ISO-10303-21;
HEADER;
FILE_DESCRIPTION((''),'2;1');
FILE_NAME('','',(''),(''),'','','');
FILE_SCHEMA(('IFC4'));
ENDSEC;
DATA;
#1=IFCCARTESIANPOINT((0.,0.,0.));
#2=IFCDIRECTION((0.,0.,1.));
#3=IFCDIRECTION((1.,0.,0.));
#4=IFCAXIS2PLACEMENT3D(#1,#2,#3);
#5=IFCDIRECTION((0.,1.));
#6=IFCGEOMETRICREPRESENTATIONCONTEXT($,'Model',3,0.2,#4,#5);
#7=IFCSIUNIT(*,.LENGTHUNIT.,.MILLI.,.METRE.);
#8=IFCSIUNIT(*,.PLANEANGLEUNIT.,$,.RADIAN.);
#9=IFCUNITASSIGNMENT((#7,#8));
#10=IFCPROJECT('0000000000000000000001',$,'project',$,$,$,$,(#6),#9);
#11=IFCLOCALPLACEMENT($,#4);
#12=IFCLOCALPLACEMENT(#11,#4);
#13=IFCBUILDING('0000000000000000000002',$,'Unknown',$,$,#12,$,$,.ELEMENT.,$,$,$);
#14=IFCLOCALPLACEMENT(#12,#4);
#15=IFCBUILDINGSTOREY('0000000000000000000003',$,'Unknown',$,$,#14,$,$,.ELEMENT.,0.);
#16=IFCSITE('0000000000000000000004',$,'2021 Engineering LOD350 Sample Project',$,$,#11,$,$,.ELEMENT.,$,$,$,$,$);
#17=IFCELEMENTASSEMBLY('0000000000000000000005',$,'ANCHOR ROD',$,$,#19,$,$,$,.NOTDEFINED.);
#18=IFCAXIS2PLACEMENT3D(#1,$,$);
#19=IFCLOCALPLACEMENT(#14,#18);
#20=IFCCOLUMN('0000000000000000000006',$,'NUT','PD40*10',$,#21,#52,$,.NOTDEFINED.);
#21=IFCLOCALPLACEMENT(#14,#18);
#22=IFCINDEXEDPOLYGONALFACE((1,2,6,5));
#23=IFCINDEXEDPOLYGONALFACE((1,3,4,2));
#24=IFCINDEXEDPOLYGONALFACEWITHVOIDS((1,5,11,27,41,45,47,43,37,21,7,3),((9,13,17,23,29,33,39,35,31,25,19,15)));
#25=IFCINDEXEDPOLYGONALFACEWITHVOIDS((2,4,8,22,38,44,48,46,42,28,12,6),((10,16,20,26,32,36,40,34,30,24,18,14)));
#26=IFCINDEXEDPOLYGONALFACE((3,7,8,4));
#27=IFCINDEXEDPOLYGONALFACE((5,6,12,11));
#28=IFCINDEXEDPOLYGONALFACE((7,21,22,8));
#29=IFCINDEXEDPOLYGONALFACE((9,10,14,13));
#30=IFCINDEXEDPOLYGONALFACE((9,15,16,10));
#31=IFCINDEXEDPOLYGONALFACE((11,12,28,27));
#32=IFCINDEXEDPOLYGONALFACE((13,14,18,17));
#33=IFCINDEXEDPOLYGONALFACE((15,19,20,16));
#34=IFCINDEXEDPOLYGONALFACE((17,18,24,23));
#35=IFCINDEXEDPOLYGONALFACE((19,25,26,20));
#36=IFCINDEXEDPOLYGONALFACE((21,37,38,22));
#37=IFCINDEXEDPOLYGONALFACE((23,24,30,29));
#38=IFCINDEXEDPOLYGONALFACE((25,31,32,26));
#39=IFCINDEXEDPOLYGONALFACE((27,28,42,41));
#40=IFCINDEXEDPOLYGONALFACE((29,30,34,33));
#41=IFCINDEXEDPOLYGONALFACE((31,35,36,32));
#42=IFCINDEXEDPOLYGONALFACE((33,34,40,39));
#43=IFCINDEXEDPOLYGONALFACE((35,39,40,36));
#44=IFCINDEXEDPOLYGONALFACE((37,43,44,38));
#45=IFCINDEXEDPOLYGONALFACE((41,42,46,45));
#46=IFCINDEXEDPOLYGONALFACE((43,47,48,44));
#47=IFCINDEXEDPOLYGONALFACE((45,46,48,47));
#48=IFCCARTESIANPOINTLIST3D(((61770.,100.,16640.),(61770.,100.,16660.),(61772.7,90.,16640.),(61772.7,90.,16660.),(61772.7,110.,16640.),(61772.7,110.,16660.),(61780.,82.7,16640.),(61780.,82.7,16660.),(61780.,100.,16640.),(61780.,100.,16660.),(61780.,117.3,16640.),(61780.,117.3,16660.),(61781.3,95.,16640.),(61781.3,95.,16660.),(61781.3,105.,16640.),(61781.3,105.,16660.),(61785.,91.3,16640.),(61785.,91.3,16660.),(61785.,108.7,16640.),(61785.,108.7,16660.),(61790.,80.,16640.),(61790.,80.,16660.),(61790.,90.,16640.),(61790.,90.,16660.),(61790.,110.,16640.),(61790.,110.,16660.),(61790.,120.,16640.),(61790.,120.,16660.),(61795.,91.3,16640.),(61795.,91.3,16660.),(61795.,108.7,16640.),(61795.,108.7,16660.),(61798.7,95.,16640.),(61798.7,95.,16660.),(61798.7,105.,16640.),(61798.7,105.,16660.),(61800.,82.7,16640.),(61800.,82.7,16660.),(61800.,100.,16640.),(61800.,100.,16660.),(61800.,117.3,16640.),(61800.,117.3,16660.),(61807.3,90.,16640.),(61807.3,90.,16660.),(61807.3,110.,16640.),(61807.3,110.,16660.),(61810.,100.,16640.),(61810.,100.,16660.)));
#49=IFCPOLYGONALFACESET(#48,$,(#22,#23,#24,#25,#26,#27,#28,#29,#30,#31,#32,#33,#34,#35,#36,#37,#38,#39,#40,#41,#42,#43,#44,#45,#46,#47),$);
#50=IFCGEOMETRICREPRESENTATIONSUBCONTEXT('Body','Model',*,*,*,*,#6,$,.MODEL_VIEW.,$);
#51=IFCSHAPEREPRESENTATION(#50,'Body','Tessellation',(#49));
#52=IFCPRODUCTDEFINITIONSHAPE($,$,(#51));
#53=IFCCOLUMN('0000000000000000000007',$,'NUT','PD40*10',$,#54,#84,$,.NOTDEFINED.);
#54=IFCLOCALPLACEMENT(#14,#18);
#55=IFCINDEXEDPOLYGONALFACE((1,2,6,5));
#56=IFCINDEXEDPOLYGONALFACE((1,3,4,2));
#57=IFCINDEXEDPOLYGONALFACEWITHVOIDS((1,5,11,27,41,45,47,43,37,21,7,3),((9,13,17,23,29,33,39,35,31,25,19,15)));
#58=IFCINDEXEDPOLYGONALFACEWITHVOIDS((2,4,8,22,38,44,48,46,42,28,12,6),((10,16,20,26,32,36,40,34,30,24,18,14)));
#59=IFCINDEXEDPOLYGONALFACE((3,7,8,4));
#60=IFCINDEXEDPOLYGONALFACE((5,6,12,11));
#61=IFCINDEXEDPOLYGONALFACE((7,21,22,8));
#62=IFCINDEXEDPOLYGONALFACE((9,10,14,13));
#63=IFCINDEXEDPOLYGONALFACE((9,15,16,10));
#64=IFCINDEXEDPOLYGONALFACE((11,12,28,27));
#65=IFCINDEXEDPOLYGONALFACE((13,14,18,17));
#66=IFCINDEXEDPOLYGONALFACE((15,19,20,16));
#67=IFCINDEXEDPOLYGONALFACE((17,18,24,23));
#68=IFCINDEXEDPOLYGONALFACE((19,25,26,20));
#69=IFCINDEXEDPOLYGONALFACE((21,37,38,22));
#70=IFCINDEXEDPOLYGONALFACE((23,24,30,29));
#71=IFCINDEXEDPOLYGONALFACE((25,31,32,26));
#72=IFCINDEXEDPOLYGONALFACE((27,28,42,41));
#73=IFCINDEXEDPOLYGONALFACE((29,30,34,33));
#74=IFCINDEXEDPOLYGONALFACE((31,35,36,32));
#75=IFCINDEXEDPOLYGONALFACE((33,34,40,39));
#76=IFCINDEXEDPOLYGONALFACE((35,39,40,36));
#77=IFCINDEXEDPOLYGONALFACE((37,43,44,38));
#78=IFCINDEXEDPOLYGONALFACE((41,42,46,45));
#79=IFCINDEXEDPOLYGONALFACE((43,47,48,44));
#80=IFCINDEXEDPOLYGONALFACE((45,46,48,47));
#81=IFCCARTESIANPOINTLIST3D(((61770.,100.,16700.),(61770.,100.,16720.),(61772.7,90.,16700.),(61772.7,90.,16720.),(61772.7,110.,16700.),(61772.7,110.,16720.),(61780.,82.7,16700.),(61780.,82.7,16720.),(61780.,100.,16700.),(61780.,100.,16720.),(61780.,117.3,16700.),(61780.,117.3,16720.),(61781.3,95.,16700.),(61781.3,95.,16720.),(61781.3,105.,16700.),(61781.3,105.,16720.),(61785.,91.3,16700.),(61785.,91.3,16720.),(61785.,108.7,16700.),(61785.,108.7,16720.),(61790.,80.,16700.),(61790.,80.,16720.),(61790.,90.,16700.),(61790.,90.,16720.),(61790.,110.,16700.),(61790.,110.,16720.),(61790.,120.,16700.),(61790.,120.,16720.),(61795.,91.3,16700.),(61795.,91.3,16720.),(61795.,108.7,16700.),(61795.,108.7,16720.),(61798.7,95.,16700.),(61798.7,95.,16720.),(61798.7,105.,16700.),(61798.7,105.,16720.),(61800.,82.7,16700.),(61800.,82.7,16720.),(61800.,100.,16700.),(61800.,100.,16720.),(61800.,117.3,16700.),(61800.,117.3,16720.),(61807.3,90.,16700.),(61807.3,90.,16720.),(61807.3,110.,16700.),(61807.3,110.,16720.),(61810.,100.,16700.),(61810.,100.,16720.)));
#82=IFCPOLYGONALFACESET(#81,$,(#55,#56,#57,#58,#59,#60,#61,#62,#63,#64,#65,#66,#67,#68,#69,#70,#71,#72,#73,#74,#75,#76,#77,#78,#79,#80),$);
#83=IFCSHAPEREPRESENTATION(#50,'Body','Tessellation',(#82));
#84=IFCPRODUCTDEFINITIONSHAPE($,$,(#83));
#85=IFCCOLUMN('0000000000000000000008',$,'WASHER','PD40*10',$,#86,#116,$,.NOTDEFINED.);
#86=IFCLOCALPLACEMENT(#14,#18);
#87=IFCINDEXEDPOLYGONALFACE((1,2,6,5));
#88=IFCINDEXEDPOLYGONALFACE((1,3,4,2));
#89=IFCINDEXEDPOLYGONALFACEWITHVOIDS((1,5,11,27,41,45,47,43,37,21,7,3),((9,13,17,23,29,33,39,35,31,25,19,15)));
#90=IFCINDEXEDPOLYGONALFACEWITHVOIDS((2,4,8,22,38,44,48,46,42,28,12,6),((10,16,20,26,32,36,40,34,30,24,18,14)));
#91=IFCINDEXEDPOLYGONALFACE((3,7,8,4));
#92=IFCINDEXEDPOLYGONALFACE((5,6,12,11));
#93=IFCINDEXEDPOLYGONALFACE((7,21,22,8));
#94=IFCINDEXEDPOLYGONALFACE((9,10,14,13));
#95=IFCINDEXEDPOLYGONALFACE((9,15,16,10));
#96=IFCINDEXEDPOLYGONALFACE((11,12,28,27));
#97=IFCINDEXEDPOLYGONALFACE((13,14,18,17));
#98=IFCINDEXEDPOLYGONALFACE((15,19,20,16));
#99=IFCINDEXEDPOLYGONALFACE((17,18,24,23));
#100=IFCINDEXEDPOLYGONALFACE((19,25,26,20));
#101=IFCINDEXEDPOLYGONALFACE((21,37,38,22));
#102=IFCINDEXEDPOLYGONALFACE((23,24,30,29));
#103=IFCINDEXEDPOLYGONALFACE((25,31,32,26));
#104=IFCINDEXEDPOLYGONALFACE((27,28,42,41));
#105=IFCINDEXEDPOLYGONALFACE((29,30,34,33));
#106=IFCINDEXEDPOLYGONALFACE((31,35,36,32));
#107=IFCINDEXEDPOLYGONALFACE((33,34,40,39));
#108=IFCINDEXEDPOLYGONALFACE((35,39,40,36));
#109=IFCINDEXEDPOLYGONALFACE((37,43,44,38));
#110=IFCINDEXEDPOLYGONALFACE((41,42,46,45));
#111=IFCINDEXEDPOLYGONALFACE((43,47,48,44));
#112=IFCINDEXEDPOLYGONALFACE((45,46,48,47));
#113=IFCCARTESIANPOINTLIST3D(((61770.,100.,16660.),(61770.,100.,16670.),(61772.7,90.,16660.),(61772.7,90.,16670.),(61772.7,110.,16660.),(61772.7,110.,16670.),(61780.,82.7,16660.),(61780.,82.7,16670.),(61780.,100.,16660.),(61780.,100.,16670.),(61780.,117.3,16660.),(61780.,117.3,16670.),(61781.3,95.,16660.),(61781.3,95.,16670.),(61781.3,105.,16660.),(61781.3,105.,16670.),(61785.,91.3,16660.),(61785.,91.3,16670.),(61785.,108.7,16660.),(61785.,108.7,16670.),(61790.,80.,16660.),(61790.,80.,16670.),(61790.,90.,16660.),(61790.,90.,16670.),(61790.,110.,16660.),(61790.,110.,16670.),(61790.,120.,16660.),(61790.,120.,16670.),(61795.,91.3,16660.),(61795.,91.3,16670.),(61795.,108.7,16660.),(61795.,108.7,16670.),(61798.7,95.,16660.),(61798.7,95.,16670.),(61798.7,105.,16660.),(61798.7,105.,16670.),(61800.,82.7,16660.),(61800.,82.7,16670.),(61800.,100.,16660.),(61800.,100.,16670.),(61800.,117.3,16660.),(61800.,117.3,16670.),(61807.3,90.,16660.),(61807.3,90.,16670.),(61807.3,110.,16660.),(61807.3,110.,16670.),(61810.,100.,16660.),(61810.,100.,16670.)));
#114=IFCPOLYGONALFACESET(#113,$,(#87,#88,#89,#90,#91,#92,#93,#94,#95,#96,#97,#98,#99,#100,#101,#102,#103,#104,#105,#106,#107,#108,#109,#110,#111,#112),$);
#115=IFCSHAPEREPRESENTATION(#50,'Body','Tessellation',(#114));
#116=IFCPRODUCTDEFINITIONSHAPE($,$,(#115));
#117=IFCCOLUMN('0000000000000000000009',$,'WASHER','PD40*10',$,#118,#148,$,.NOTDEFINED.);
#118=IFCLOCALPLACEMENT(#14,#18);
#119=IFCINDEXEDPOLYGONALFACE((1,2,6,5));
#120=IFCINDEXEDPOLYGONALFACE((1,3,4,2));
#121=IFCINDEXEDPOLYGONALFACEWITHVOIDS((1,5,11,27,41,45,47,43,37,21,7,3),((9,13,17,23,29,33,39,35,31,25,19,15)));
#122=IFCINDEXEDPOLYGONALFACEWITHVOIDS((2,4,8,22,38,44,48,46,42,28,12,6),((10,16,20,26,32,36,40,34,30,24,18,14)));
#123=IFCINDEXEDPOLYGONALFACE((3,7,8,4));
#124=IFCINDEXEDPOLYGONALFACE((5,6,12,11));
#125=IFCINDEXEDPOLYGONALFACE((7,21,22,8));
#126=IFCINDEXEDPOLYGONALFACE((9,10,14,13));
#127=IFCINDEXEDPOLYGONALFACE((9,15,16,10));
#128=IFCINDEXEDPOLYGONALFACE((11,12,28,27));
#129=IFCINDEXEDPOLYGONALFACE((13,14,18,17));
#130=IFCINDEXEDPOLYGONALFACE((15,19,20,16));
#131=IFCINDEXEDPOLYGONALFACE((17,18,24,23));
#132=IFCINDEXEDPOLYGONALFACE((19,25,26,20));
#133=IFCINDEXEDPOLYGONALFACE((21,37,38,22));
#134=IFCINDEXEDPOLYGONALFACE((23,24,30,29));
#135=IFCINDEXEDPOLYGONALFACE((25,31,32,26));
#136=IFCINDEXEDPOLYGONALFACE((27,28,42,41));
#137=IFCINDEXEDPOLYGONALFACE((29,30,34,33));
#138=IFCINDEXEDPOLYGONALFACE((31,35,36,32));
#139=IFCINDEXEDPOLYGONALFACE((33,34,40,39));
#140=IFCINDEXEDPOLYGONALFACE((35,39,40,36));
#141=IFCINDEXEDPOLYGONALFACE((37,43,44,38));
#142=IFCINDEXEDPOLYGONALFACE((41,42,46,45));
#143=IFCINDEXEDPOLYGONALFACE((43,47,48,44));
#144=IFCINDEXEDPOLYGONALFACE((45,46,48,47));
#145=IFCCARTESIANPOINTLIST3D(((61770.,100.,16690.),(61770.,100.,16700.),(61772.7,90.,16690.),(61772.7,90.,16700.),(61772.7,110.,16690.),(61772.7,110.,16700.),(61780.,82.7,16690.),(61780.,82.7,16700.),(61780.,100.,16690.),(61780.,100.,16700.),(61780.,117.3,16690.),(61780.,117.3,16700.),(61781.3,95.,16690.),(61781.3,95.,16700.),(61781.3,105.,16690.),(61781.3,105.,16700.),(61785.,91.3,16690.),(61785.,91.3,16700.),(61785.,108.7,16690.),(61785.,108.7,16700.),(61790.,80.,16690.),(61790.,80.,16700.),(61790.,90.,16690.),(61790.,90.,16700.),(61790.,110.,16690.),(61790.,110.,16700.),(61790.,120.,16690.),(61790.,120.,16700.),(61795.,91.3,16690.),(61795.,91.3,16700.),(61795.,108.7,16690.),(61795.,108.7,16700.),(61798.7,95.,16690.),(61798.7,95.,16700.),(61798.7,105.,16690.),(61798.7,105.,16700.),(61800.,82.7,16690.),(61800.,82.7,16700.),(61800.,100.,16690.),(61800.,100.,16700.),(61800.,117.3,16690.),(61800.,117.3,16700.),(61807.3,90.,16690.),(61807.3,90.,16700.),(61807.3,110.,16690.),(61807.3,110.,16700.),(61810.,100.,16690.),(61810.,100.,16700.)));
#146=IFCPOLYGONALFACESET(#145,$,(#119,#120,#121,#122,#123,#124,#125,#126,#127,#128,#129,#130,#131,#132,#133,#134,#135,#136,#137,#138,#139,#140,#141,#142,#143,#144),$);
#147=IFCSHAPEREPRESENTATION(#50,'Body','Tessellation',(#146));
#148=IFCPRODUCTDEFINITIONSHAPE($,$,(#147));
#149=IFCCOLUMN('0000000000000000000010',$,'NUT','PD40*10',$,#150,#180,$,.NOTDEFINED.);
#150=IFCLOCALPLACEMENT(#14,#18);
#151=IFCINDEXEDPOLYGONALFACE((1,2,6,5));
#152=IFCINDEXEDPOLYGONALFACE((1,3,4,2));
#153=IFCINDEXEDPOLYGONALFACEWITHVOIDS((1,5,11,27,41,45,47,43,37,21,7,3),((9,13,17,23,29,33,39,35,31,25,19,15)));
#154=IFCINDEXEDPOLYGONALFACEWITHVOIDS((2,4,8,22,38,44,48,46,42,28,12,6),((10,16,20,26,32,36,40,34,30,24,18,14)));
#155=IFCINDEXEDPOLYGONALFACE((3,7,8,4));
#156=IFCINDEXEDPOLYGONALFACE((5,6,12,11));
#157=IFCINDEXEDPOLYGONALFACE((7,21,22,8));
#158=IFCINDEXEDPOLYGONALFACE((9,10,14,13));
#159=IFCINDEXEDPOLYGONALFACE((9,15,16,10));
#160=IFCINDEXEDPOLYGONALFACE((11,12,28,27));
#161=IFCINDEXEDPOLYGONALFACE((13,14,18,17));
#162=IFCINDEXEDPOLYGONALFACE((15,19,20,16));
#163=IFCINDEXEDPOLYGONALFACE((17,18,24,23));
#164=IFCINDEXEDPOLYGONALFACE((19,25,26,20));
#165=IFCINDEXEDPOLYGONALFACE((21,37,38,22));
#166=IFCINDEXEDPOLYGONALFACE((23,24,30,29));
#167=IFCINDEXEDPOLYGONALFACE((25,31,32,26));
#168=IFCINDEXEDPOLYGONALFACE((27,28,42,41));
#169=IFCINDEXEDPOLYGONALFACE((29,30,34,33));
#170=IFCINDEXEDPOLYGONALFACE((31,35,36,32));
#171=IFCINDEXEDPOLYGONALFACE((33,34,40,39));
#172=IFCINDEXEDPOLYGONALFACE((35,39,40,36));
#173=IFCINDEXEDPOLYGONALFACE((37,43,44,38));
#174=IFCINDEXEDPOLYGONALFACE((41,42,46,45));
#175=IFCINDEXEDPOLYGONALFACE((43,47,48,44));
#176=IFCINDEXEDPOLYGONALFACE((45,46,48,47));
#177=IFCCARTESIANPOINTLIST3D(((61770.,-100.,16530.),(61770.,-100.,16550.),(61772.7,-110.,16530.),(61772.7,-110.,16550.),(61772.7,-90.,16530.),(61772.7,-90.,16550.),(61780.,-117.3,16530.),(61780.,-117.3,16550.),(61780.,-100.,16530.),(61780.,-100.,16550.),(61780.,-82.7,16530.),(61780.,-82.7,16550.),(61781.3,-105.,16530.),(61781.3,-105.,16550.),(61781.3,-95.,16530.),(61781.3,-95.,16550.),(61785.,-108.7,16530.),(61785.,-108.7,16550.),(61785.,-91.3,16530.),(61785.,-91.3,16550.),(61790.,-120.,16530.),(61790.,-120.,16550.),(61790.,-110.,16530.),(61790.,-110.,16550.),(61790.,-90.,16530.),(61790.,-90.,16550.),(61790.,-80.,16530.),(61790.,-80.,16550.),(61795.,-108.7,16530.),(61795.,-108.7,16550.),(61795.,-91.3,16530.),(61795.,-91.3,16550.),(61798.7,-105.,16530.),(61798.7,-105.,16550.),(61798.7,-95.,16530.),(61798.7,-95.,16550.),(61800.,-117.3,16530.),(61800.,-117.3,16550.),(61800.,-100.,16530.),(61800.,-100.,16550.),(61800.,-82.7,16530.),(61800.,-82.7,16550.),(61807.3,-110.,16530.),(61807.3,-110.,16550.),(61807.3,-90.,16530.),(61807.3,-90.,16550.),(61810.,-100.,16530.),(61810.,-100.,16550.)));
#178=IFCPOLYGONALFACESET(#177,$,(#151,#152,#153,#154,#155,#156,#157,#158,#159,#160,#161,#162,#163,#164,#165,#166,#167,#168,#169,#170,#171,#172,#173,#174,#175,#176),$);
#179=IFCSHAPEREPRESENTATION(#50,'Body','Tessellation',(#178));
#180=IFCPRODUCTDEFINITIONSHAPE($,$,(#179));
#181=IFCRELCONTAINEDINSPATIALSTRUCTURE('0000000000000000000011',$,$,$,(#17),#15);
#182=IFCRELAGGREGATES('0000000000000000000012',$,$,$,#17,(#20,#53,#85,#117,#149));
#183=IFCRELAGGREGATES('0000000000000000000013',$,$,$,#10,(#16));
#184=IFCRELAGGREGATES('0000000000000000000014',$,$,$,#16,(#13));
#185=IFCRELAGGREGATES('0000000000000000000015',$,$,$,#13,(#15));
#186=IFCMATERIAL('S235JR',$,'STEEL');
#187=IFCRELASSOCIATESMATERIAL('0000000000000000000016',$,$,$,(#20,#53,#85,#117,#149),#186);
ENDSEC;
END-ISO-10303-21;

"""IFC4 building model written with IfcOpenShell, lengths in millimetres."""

from ifc_helpers import new_model, si_unit, direction, frame, origin_with_axes, place, context, subcontext, project, spatial, line, indexed_curve, outline, extrude, material, element, aggregate, save


model = new_model("IFC4")

# Units and contexts
model_context = context("Model", 3, precision=0.2, world=origin_with_axes(), true_north=direction((0.0, 1.0)))
body_context = subcontext(model_context, "Body", "Model", "MODEL_VIEW")
ifc_project = project(units=[si_unit("LENGTHUNIT", "METRE", prefix="MILLI"), si_unit("PLANEANGLEUNIT", "RADIAN")], contexts=[model_context])

# Site, building, storey
site_placement = place(None, origin_with_axes())
site = spatial("IfcSite", under=ifc_project, at=site_placement, Name="2021 Engineering LOD350 Sample Project", CompositionType="ELEMENT")
building_placement = place(site_placement, origin_with_axes())
building = spatial("IfcBuilding", under=site, at=building_placement, Name="Unknown", CompositionType="ELEMENT")
storey_placement = place(building_placement, origin_with_axes())
storey = spatial("IfcBuildingStorey", under=building, at=storey_placement, Name="Unknown", CompositionType="ELEMENT", Elevation=0.0)

# Shared definitions
ifc_material_1 = material(Name="S235JR", Category="STEEL")

# Element assembly, columns
assembly_1_placement = place(storey_placement, frame((61790.0, 100.0, 16730.0), z_axis=(1.0, 0.0, 0.0), x_axis=(0.0, 0.0, -1.0)))
assembly_1 = element("IfcElementAssembly", 1, at=assembly_1_placement, inside=storey, Name="ANCHOR ROD", PredefinedType="NOTDEFINED")
column_1_placement = place(assembly_1_placement, frame((70.0, 0.0, 0.0), z_axis=(0.0, 0.0, 1.0), x_axis=(1.0, 0.0, 0.0)))
column_1 = element("IfcColumn", 2, at=column_1_placement, material=ifc_material_1, Name="NUT", Description="PD40*10", PredefinedType="NOTDEFINED", context=body_context, shape_type="SolidModel", body=[
    extrude(outline(indexed_curve([(20.0, 0.0), (17.3, 10.0), (10.0, 17.3), (0.0, 20.0), (-10.0, 17.3), (-17.3, 10.0), (-20.0, 0.0), (-17.3, -10.0), (-10.0, -17.3), (0.0, -20.0), (10.0, -17.3), (17.3, -10.0)], segments=[line(1, 2, 3, 4, 5, 6, 7, 8, 9, 10, 11, 12, 1)]), holes=[indexed_curve([(10.0, 0.0), (8.7, -5.0), (5.0, -8.7), (0.0, -10.0), (-5.0, -8.7), (-8.7, -5.0), (-10.0, 0.0), (-8.7, 5.0), (-5.0, 8.7), (0.0, 10.0), (5.0, 8.7), (8.7, 5.0)], segments=[line(1, 2, 3, 4, 5, 6, 7, 8, 9, 10, 11, 12, 1)])]), frame((0.0, 0.0, 0.0), z_axis=(-1.0, 0.0, 0.0), x_axis=(0.0, 0.0, 1.0)), (0.0, 0.0, -1.0), 20.0),
])
column_2_placement = place(assembly_1_placement, frame((10.0, 0.0, 0.0), z_axis=(0.0, 0.0, 1.0), x_axis=(1.0, 0.0, 0.0)))
column_2 = element("IfcColumn", 3, at=column_2_placement, material=ifc_material_1, Name="NUT", Description="PD40*10", PredefinedType="NOTDEFINED", context=body_context, shape_type="SolidModel", body=[
    extrude(outline(indexed_curve([(20.0, 0.0), (17.3, 10.0), (10.0, 17.3), (0.0, 20.0), (-10.0, 17.3), (-17.3, 10.0), (-20.0, 0.0), (-17.3, -10.0), (-10.0, -17.3), (0.0, -20.0), (10.0, -17.3), (17.3, -10.0)], segments=[line(1, 2, 3, 4, 5, 6, 7, 8, 9, 10, 11, 12, 1)]), holes=[indexed_curve([(10.0, 0.0), (8.7, -5.0), (5.0, -8.7), (0.0, -10.0), (-5.0, -8.7), (-8.7, -5.0), (-10.0, 0.0), (-8.7, 5.0), (-5.0, 8.7), (0.0, 10.0), (5.0, 8.7), (8.7, 5.0)], segments=[line(1, 2, 3, 4, 5, 6, 7, 8, 9, 10, 11, 12, 1)])]), frame((0.0, 0.0, 0.0), z_axis=(-1.0, 0.0, 0.0), x_axis=(0.0, 0.0, 1.0)), (0.0, 0.0, -1.0), 20.0),
])
column_3_placement = place(assembly_1_placement, frame((60.0, 0.0, 0.0), z_axis=(0.0, 0.0, 1.0), x_axis=(1.0, 0.0, 0.0)))
column_3 = element("IfcColumn", 4, at=column_3_placement, material=ifc_material_1, Name="WASHER", Description="PD40*10", PredefinedType="NOTDEFINED", context=body_context, shape_type="SolidModel", body=[
    extrude(outline(indexed_curve([(20.0, 0.0), (17.3, 10.0), (10.0, 17.3), (0.0, 20.0), (-10.0, 17.3), (-17.3, 10.0), (-20.0, 0.0), (-17.3, -10.0), (-10.0, -17.3), (0.0, -20.0), (10.0, -17.3), (17.3, -10.0)], segments=[line(1, 2, 3, 4, 5, 6, 7, 8, 9, 10, 11, 12, 1)]), holes=[indexed_curve([(10.0, 0.0), (8.7, -5.0), (5.0, -8.7), (0.0, -10.0), (-5.0, -8.7), (-8.7, -5.0), (-10.0, 0.0), (-8.7, 5.0), (-5.0, 8.7), (0.0, 10.0), (5.0, 8.7), (8.7, 5.0)], segments=[line(1, 2, 3, 4, 5, 6, 7, 8, 9, 10, 11, 12, 1)])]), frame((0.0, 0.0, 0.0), z_axis=(-1.0, 0.0, 0.0), x_axis=(0.0, 0.0, 1.0)), (0.0, 0.0, -1.0), 10.0),
])
column_4_placement = place(assembly_1_placement, frame((30.0, 0.0, 0.0), z_axis=(0.0, 0.0, 1.0), x_axis=(1.0, 0.0, 0.0)))
column_4 = element("IfcColumn", 5, at=column_4_placement, material=ifc_material_1, Name="WASHER", Description="PD40*10", PredefinedType="NOTDEFINED", context=body_context, shape_type="SolidModel", body=[
    extrude(outline(indexed_curve([(20.0, 0.0), (17.3, 10.0), (10.0, 17.3), (0.0, 20.0), (-10.0, 17.3), (-17.3, 10.0), (-20.0, 0.0), (-17.3, -10.0), (-10.0, -17.3), (0.0, -20.0), (10.0, -17.3), (17.3, -10.0)], segments=[line(1, 2, 3, 4, 5, 6, 7, 8, 9, 10, 11, 12, 1)]), holes=[indexed_curve([(10.0, 0.0), (8.7, -5.0), (5.0, -8.7), (0.0, -10.0), (-5.0, -8.7), (-8.7, -5.0), (-10.0, 0.0), (-8.7, 5.0), (-5.0, 8.7), (0.0, 10.0), (5.0, 8.7), (8.7, 5.0)], segments=[line(1, 2, 3, 4, 5, 6, 7, 8, 9, 10, 11, 12, 1)])]), frame((0.0, 0.0, 0.0), z_axis=(-1.0, 0.0, 0.0), x_axis=(0.0, 0.0, 1.0)), (0.0, 0.0, -1.0), 10.0),
])
column_5_placement = place(assembly_1_placement, frame((180.0, -200.0, 0.0), z_axis=(0.0, 0.0, 1.0), x_axis=(1.0, 0.0, 0.0)))
column_5 = element("IfcColumn", 6, at=column_5_placement, material=ifc_material_1, Name="NUT", Description="PD40*10", PredefinedType="NOTDEFINED", context=body_context, shape_type="SolidModel", body=[
    extrude(outline(indexed_curve([(20.0, 0.0), (17.3, 10.0), (10.0, 17.3), (0.0, 20.0), (-10.0, 17.3), (-17.3, 10.0), (-20.0, 0.0), (-17.3, -10.0), (-10.0, -17.3), (0.0, -20.0), (10.0, -17.3), (17.3, -10.0)], segments=[line(1, 2, 3, 4, 5, 6, 7, 8, 9, 10, 11, 12, 1)]), holes=[indexed_curve([(10.0, 0.0), (8.7, -5.0), (5.0, -8.7), (0.0, -10.0), (-5.0, -8.7), (-8.7, -5.0), (-10.0, 0.0), (-8.7, 5.0), (-5.0, 8.7), (0.0, 10.0), (5.0, 8.7), (8.7, 5.0)], segments=[line(1, 2, 3, 4, 5, 6, 7, 8, 9, 10, 11, 12, 1)])]), frame((0.0, 0.0, 0.0), z_axis=(-1.0, 0.0, 0.0), x_axis=(0.0, 0.0, 1.0)), (0.0, 0.0, -1.0), 20.0),
])

aggregate(assembly_1, [column_1, column_2, column_3, column_4, column_5])

save(model, "model.ifc")
